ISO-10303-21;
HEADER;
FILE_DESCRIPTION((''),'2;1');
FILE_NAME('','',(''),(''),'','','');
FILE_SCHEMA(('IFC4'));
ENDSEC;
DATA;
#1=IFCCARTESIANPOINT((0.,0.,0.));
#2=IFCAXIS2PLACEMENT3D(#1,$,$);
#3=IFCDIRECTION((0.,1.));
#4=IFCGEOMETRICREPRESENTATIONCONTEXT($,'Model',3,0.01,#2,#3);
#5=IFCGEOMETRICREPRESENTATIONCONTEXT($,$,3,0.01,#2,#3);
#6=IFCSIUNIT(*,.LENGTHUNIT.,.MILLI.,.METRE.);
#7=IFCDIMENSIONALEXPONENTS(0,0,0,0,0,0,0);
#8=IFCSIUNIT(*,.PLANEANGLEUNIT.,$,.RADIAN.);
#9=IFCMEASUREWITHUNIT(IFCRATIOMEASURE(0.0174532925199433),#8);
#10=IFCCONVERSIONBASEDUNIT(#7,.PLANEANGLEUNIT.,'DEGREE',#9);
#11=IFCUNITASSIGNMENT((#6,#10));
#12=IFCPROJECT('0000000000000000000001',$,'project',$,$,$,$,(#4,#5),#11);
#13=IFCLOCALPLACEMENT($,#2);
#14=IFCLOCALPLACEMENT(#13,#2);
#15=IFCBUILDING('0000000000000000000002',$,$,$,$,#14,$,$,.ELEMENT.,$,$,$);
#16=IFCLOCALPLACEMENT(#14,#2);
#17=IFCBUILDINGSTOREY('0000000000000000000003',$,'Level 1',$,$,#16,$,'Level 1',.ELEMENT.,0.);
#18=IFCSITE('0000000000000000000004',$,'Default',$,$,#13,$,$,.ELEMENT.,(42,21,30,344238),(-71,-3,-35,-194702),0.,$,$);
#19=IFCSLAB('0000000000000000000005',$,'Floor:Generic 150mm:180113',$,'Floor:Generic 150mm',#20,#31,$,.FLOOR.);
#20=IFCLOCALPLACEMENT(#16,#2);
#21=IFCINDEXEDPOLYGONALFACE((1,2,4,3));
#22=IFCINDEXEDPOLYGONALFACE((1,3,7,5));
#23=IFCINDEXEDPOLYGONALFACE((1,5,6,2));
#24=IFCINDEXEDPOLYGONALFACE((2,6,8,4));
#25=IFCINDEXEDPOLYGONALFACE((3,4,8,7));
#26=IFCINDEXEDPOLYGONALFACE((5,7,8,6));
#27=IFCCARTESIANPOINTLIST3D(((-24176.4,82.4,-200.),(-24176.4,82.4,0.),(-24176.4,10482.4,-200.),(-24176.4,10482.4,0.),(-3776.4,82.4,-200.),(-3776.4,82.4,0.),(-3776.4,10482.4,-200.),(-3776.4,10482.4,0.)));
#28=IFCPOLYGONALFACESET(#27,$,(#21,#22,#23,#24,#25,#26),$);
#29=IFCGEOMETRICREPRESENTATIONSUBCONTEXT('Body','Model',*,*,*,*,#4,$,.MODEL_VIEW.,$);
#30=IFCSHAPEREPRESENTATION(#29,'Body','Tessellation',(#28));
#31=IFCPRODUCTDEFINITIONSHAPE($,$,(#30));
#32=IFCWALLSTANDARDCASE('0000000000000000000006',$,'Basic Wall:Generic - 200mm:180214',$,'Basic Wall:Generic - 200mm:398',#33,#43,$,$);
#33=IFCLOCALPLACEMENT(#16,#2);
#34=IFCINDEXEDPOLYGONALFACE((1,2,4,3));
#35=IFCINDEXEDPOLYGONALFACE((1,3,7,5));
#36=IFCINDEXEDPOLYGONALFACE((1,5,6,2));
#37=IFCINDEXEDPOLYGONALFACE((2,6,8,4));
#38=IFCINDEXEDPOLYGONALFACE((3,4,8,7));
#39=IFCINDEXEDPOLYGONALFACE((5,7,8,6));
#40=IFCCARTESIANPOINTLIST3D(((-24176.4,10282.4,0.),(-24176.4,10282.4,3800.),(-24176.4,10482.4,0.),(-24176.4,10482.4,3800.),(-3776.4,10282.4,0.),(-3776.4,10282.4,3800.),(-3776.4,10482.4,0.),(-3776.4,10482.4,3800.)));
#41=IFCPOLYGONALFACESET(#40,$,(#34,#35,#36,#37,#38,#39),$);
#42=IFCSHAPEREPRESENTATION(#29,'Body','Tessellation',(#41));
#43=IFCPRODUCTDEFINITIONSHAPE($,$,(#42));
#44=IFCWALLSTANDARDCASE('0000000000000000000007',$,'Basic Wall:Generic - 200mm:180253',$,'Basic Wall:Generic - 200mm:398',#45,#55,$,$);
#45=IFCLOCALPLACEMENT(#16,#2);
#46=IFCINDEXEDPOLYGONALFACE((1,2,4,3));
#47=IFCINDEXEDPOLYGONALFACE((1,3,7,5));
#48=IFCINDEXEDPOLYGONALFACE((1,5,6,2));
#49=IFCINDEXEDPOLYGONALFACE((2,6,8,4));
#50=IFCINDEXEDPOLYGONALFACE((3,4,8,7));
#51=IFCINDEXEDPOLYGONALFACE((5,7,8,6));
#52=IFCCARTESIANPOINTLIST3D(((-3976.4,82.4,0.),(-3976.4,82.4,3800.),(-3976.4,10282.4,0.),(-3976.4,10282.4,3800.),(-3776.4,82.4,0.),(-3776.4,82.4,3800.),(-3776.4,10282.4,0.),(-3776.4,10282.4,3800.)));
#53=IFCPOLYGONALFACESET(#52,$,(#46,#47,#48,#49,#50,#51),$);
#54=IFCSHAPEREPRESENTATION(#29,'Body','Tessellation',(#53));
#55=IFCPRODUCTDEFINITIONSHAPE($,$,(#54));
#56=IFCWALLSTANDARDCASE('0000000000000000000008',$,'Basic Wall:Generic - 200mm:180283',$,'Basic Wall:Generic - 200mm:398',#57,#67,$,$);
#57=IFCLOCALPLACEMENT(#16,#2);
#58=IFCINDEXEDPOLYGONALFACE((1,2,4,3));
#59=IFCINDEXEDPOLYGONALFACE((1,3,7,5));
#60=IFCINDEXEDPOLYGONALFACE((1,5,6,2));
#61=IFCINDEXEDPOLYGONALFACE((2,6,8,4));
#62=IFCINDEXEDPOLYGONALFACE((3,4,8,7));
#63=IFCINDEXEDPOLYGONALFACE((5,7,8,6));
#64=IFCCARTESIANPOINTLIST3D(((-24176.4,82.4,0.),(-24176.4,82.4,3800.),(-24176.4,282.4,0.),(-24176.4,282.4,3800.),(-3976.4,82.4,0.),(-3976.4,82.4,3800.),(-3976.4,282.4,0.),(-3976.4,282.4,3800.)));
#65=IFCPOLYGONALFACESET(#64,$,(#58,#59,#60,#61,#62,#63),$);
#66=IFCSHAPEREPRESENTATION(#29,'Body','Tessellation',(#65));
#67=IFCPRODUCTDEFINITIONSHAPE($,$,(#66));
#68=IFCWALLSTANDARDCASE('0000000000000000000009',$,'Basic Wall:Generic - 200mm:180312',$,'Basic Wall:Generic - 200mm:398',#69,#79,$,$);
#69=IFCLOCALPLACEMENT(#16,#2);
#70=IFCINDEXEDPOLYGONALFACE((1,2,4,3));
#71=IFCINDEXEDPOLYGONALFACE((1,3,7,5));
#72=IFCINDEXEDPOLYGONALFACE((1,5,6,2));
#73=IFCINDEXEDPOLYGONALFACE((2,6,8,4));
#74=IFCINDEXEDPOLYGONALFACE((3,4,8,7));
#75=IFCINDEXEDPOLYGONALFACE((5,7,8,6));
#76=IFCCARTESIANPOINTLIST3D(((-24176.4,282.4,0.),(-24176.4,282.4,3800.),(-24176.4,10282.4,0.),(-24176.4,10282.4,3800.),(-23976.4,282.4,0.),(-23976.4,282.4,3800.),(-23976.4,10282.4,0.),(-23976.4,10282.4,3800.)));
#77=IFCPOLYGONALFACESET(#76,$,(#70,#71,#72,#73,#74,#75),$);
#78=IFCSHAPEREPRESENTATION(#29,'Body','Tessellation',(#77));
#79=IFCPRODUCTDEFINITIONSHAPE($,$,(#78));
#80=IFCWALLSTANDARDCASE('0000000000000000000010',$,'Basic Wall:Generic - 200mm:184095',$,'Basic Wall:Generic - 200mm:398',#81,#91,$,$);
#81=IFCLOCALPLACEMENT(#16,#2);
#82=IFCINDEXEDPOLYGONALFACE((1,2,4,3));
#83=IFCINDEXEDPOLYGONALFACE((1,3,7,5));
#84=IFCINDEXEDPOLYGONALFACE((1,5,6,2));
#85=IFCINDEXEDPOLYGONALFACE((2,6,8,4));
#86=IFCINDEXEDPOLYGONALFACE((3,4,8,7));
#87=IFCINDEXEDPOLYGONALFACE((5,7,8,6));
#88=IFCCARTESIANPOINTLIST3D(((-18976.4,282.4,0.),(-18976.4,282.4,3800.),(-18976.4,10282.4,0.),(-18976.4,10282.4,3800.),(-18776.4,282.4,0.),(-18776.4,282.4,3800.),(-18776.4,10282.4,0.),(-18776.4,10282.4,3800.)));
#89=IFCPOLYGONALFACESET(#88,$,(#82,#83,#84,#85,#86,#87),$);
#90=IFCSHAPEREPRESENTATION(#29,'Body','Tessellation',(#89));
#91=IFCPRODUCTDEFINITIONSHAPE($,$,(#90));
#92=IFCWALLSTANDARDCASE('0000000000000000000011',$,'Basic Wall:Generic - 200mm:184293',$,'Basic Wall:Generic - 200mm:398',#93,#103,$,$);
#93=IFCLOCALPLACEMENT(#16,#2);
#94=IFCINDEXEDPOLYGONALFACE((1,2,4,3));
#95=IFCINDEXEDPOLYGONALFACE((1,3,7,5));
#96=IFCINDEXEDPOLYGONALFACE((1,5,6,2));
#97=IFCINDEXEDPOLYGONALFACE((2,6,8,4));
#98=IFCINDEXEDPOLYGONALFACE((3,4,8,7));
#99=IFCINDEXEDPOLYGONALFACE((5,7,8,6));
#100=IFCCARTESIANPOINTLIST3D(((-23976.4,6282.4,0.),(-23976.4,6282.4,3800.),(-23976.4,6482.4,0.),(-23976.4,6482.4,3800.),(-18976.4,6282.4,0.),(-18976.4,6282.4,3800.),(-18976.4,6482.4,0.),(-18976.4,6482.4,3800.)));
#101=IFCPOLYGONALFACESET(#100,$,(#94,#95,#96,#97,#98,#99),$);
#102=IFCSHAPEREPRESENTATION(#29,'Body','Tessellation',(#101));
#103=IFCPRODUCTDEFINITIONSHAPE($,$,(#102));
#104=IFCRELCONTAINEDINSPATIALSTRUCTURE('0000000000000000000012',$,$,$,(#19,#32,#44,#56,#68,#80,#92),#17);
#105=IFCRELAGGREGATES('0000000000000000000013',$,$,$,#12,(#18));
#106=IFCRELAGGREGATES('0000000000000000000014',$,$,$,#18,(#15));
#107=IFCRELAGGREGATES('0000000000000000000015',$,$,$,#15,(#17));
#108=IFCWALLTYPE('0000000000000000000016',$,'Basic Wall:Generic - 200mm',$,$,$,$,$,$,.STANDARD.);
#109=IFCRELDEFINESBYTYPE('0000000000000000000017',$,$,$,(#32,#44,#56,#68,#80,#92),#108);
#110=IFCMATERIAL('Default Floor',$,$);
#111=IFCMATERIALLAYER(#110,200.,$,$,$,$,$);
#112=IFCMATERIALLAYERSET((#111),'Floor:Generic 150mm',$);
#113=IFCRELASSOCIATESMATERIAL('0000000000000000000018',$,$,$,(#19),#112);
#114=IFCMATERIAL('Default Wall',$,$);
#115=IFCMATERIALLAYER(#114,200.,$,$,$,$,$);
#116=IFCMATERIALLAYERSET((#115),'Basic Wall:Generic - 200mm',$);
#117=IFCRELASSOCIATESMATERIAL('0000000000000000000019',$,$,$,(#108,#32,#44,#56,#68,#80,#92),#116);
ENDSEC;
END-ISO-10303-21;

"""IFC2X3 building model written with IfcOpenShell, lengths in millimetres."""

from ifc_helpers import new_model, entity, si_unit, converted_unit, direction, frame, frame_2d, origin, origin_2d_with_axis, place, context, subcontext, project, spatial, rectangle, extrude, material, layer, layer_set, layer_usage, type_object, element, save


model = new_model("IFC2X3")

# Units and contexts
model_context = context("Model", 3, precision=0.01, world=origin(), true_north=direction((0.0, 1.0)))
context_of_model = context(None, 3, precision=0.01, world=origin(), true_north=direction((0.0, 1.0)))
body_context = subcontext(model_context, "Body", "Model", "MODEL_VIEW")
ifc_project = project(units=[si_unit("LENGTHUNIT", "METRE", prefix="MILLI"), converted_unit("PLANEANGLEUNIT", "DEGREE", entity("IfcRatioMeasure", 0.0174532925199433), si_unit("PLANEANGLEUNIT", "RADIAN"), dimensions=[0, 0, 0, 0, 0, 0, 0])], contexts=[model_context, context_of_model])

# Site, building, storey
site_placement = place(None, origin())
site = spatial("IfcSite", under=ifc_project, at=site_placement, Name="Default", CompositionType="ELEMENT", RefLatitude=(42, 21, 30, 344238), RefLongitude=(-71, -3, -35, -194702), RefElevation=0.0)
building_placement = place(site_placement, origin())
building = spatial("IfcBuilding", under=site, at=building_placement, CompositionType="ELEMENT")
storey_placement = place(building_placement, origin())
storey = spatial("IfcBuildingStorey", under=building, at=storey_placement, Name="Level 1", LongName="Level 1", CompositionType="ELEMENT", Elevation=0.0)

# Slab
ifc_material_1 = material(Name="Default Floor")
ifc_layer_1 = layer(ifc_material_1, 200.0)
ifc_layer_set_1 = layer_set([ifc_layer_1], Name="Floor:Generic 150mm")
ifc_layer_usage_1 = layer_usage(ifc_layer_set_1, "AXIS3", "POSITIVE", 0.0)
slab_placement = place(storey_placement, origin())
element("IfcSlab", 1, at=slab_placement, inside=storey, material=ifc_layer_usage_1, Name="Floor:Generic 150mm:180113", ObjectType="Floor:Generic 150mm", PredefinedType="FLOOR", context=body_context, shape_type="SweptSolid", body=[
    extrude(rectangle(XDim=10400.0, YDim=20400.0, at=origin_2d_with_axis()), frame((-13976.4, 5282.4, 0.0), z_axis=(0.0, 0.0, -1.0), x_axis=(0.0, 1.0, 0.0)), (0.0, 0.0, 1.0), 200.0),
])

# Walls
ifc_material_2 = material(Name="Default Wall")
ifc_layer_2 = layer(ifc_material_2, 200.0)
ifc_layer_set_2 = layer_set([ifc_layer_2], Name="Basic Wall:Generic - 200mm")
ifc_layer_usage_2 = layer_usage(ifc_layer_set_2, "AXIS2", "NEGATIVE", 100.0)
wall_type = type_object("IfcWallType", Name="Basic Wall:Generic - 200mm", PredefinedType="STANDARD", material=ifc_layer_set_2)
wall_1_placement = place(storey_placement, frame((-24176.4, 10382.4, 0.0)))
element("IfcWallStandardCase", 2, at=wall_1_placement, inside=storey, type_object=wall_type, material=ifc_layer_usage_2, Name="Basic Wall:Generic - 200mm:180214", ObjectType="Basic Wall:Generic - 200mm:398", context=body_context, shape_type="SweptSolid", body=[
    extrude(rectangle(XDim=20400.0, YDim=200.0, at=frame_2d((10200.0, 0.0), x_axis=(-1.0, 0.0))), origin(), (0.0, 0.0, 1.0), 3800.0),
])
ifc_layer_usage_3 = layer_usage(ifc_layer_set_2, "AXIS2", "NEGATIVE", 100.0)
wall_2_placement = place(storey_placement, frame((-3876.4, 10282.4, 0.0), z_axis=(0.0, 0.0, 1.0), x_axis=(0.0, -1.0, 0.0)))
element("IfcWallStandardCase", 3, at=wall_2_placement, inside=storey, type_object=wall_type, material=ifc_layer_usage_3, Name="Basic Wall:Generic - 200mm:180253", ObjectType="Basic Wall:Generic - 200mm:398", context=body_context, shape_type="SweptSolid", body=[
    extrude(rectangle(XDim=10200.0, YDim=200.0, at=frame_2d((5100.0, 0.0), x_axis=(-1.0, 0.0))), origin(), (0.0, 0.0, 1.0), 3800.0),
])
ifc_layer_usage_4 = layer_usage(ifc_layer_set_2, "AXIS2", "NEGATIVE", 100.0)
wall_3_placement = place(storey_placement, frame((-3976.4, 182.4, 0.0), z_axis=(0.0, 0.0, 1.0), x_axis=(-1.0, 0.0, 0.0)))
element("IfcWallStandardCase", 4, at=wall_3_placement, inside=storey, type_object=wall_type, material=ifc_layer_usage_4, Name="Basic Wall:Generic - 200mm:180283", ObjectType="Basic Wall:Generic - 200mm:398", context=body_context, shape_type="SweptSolid", body=[
    extrude(rectangle(XDim=20200.0, YDim=200.0, at=frame_2d((10100.0, 0.0), x_axis=(-1.0, 0.0))), origin(), (0.0, 0.0, 1.0), 3800.0),
])
ifc_layer_usage_5 = layer_usage(ifc_layer_set_2, "AXIS2", "NEGATIVE", 100.0)
wall_4_placement = place(storey_placement, frame((-24076.4, 282.4, 0.0), z_axis=(0.0, 0.0, 1.0), x_axis=(0.0, 1.0, 0.0)))
element("IfcWallStandardCase", 5, at=wall_4_placement, inside=storey, type_object=wall_type, material=ifc_layer_usage_5, Name="Basic Wall:Generic - 200mm:180312", ObjectType="Basic Wall:Generic - 200mm:398", context=body_context, shape_type="SweptSolid", body=[
    extrude(rectangle(XDim=10000.0, YDim=200.0, at=frame_2d((5000.0, 0.0), x_axis=(-1.0, 0.0))), origin(), (0.0, 0.0, 1.0), 3800.0),
])
ifc_layer_usage_6 = layer_usage(ifc_layer_set_2, "AXIS2", "NEGATIVE", 100.0)
wall_5_placement = place(storey_placement, frame((-18876.4, 10282.4, 0.0), z_axis=(0.0, 0.0, 1.0), x_axis=(0.0, -1.0, 0.0)))
element("IfcWallStandardCase", 6, at=wall_5_placement, inside=storey, type_object=wall_type, material=ifc_layer_usage_6, Name="Basic Wall:Generic - 200mm:184095", ObjectType="Basic Wall:Generic - 200mm:398", context=body_context, shape_type="SweptSolid", body=[
    extrude(rectangle(XDim=10000.0, YDim=200.0, at=frame_2d((5000.0, 0.0), x_axis=(-1.0, 0.0))), origin(), (0.0, 0.0, 1.0), 3800.0),
])
ifc_layer_usage_7 = layer_usage(ifc_layer_set_2, "AXIS2", "NEGATIVE", 100.0)
wall_6_placement = place(storey_placement, frame((-23976.4, 6382.4, 0.0)))
element("IfcWallStandardCase", 7, at=wall_6_placement, inside=storey, type_object=wall_type, material=ifc_layer_usage_7, Name="Basic Wall:Generic - 200mm:184293", ObjectType="Basic Wall:Generic - 200mm:398", context=body_context, shape_type="SweptSolid", body=[
    extrude(rectangle(XDim=5000.0, YDim=200.0, at=frame_2d((2500.0, 0.0), x_axis=(-1.0, 0.0))), origin(), (0.0, 0.0, 1.0), 3800.0),
])

save(model, "model.ifc")
